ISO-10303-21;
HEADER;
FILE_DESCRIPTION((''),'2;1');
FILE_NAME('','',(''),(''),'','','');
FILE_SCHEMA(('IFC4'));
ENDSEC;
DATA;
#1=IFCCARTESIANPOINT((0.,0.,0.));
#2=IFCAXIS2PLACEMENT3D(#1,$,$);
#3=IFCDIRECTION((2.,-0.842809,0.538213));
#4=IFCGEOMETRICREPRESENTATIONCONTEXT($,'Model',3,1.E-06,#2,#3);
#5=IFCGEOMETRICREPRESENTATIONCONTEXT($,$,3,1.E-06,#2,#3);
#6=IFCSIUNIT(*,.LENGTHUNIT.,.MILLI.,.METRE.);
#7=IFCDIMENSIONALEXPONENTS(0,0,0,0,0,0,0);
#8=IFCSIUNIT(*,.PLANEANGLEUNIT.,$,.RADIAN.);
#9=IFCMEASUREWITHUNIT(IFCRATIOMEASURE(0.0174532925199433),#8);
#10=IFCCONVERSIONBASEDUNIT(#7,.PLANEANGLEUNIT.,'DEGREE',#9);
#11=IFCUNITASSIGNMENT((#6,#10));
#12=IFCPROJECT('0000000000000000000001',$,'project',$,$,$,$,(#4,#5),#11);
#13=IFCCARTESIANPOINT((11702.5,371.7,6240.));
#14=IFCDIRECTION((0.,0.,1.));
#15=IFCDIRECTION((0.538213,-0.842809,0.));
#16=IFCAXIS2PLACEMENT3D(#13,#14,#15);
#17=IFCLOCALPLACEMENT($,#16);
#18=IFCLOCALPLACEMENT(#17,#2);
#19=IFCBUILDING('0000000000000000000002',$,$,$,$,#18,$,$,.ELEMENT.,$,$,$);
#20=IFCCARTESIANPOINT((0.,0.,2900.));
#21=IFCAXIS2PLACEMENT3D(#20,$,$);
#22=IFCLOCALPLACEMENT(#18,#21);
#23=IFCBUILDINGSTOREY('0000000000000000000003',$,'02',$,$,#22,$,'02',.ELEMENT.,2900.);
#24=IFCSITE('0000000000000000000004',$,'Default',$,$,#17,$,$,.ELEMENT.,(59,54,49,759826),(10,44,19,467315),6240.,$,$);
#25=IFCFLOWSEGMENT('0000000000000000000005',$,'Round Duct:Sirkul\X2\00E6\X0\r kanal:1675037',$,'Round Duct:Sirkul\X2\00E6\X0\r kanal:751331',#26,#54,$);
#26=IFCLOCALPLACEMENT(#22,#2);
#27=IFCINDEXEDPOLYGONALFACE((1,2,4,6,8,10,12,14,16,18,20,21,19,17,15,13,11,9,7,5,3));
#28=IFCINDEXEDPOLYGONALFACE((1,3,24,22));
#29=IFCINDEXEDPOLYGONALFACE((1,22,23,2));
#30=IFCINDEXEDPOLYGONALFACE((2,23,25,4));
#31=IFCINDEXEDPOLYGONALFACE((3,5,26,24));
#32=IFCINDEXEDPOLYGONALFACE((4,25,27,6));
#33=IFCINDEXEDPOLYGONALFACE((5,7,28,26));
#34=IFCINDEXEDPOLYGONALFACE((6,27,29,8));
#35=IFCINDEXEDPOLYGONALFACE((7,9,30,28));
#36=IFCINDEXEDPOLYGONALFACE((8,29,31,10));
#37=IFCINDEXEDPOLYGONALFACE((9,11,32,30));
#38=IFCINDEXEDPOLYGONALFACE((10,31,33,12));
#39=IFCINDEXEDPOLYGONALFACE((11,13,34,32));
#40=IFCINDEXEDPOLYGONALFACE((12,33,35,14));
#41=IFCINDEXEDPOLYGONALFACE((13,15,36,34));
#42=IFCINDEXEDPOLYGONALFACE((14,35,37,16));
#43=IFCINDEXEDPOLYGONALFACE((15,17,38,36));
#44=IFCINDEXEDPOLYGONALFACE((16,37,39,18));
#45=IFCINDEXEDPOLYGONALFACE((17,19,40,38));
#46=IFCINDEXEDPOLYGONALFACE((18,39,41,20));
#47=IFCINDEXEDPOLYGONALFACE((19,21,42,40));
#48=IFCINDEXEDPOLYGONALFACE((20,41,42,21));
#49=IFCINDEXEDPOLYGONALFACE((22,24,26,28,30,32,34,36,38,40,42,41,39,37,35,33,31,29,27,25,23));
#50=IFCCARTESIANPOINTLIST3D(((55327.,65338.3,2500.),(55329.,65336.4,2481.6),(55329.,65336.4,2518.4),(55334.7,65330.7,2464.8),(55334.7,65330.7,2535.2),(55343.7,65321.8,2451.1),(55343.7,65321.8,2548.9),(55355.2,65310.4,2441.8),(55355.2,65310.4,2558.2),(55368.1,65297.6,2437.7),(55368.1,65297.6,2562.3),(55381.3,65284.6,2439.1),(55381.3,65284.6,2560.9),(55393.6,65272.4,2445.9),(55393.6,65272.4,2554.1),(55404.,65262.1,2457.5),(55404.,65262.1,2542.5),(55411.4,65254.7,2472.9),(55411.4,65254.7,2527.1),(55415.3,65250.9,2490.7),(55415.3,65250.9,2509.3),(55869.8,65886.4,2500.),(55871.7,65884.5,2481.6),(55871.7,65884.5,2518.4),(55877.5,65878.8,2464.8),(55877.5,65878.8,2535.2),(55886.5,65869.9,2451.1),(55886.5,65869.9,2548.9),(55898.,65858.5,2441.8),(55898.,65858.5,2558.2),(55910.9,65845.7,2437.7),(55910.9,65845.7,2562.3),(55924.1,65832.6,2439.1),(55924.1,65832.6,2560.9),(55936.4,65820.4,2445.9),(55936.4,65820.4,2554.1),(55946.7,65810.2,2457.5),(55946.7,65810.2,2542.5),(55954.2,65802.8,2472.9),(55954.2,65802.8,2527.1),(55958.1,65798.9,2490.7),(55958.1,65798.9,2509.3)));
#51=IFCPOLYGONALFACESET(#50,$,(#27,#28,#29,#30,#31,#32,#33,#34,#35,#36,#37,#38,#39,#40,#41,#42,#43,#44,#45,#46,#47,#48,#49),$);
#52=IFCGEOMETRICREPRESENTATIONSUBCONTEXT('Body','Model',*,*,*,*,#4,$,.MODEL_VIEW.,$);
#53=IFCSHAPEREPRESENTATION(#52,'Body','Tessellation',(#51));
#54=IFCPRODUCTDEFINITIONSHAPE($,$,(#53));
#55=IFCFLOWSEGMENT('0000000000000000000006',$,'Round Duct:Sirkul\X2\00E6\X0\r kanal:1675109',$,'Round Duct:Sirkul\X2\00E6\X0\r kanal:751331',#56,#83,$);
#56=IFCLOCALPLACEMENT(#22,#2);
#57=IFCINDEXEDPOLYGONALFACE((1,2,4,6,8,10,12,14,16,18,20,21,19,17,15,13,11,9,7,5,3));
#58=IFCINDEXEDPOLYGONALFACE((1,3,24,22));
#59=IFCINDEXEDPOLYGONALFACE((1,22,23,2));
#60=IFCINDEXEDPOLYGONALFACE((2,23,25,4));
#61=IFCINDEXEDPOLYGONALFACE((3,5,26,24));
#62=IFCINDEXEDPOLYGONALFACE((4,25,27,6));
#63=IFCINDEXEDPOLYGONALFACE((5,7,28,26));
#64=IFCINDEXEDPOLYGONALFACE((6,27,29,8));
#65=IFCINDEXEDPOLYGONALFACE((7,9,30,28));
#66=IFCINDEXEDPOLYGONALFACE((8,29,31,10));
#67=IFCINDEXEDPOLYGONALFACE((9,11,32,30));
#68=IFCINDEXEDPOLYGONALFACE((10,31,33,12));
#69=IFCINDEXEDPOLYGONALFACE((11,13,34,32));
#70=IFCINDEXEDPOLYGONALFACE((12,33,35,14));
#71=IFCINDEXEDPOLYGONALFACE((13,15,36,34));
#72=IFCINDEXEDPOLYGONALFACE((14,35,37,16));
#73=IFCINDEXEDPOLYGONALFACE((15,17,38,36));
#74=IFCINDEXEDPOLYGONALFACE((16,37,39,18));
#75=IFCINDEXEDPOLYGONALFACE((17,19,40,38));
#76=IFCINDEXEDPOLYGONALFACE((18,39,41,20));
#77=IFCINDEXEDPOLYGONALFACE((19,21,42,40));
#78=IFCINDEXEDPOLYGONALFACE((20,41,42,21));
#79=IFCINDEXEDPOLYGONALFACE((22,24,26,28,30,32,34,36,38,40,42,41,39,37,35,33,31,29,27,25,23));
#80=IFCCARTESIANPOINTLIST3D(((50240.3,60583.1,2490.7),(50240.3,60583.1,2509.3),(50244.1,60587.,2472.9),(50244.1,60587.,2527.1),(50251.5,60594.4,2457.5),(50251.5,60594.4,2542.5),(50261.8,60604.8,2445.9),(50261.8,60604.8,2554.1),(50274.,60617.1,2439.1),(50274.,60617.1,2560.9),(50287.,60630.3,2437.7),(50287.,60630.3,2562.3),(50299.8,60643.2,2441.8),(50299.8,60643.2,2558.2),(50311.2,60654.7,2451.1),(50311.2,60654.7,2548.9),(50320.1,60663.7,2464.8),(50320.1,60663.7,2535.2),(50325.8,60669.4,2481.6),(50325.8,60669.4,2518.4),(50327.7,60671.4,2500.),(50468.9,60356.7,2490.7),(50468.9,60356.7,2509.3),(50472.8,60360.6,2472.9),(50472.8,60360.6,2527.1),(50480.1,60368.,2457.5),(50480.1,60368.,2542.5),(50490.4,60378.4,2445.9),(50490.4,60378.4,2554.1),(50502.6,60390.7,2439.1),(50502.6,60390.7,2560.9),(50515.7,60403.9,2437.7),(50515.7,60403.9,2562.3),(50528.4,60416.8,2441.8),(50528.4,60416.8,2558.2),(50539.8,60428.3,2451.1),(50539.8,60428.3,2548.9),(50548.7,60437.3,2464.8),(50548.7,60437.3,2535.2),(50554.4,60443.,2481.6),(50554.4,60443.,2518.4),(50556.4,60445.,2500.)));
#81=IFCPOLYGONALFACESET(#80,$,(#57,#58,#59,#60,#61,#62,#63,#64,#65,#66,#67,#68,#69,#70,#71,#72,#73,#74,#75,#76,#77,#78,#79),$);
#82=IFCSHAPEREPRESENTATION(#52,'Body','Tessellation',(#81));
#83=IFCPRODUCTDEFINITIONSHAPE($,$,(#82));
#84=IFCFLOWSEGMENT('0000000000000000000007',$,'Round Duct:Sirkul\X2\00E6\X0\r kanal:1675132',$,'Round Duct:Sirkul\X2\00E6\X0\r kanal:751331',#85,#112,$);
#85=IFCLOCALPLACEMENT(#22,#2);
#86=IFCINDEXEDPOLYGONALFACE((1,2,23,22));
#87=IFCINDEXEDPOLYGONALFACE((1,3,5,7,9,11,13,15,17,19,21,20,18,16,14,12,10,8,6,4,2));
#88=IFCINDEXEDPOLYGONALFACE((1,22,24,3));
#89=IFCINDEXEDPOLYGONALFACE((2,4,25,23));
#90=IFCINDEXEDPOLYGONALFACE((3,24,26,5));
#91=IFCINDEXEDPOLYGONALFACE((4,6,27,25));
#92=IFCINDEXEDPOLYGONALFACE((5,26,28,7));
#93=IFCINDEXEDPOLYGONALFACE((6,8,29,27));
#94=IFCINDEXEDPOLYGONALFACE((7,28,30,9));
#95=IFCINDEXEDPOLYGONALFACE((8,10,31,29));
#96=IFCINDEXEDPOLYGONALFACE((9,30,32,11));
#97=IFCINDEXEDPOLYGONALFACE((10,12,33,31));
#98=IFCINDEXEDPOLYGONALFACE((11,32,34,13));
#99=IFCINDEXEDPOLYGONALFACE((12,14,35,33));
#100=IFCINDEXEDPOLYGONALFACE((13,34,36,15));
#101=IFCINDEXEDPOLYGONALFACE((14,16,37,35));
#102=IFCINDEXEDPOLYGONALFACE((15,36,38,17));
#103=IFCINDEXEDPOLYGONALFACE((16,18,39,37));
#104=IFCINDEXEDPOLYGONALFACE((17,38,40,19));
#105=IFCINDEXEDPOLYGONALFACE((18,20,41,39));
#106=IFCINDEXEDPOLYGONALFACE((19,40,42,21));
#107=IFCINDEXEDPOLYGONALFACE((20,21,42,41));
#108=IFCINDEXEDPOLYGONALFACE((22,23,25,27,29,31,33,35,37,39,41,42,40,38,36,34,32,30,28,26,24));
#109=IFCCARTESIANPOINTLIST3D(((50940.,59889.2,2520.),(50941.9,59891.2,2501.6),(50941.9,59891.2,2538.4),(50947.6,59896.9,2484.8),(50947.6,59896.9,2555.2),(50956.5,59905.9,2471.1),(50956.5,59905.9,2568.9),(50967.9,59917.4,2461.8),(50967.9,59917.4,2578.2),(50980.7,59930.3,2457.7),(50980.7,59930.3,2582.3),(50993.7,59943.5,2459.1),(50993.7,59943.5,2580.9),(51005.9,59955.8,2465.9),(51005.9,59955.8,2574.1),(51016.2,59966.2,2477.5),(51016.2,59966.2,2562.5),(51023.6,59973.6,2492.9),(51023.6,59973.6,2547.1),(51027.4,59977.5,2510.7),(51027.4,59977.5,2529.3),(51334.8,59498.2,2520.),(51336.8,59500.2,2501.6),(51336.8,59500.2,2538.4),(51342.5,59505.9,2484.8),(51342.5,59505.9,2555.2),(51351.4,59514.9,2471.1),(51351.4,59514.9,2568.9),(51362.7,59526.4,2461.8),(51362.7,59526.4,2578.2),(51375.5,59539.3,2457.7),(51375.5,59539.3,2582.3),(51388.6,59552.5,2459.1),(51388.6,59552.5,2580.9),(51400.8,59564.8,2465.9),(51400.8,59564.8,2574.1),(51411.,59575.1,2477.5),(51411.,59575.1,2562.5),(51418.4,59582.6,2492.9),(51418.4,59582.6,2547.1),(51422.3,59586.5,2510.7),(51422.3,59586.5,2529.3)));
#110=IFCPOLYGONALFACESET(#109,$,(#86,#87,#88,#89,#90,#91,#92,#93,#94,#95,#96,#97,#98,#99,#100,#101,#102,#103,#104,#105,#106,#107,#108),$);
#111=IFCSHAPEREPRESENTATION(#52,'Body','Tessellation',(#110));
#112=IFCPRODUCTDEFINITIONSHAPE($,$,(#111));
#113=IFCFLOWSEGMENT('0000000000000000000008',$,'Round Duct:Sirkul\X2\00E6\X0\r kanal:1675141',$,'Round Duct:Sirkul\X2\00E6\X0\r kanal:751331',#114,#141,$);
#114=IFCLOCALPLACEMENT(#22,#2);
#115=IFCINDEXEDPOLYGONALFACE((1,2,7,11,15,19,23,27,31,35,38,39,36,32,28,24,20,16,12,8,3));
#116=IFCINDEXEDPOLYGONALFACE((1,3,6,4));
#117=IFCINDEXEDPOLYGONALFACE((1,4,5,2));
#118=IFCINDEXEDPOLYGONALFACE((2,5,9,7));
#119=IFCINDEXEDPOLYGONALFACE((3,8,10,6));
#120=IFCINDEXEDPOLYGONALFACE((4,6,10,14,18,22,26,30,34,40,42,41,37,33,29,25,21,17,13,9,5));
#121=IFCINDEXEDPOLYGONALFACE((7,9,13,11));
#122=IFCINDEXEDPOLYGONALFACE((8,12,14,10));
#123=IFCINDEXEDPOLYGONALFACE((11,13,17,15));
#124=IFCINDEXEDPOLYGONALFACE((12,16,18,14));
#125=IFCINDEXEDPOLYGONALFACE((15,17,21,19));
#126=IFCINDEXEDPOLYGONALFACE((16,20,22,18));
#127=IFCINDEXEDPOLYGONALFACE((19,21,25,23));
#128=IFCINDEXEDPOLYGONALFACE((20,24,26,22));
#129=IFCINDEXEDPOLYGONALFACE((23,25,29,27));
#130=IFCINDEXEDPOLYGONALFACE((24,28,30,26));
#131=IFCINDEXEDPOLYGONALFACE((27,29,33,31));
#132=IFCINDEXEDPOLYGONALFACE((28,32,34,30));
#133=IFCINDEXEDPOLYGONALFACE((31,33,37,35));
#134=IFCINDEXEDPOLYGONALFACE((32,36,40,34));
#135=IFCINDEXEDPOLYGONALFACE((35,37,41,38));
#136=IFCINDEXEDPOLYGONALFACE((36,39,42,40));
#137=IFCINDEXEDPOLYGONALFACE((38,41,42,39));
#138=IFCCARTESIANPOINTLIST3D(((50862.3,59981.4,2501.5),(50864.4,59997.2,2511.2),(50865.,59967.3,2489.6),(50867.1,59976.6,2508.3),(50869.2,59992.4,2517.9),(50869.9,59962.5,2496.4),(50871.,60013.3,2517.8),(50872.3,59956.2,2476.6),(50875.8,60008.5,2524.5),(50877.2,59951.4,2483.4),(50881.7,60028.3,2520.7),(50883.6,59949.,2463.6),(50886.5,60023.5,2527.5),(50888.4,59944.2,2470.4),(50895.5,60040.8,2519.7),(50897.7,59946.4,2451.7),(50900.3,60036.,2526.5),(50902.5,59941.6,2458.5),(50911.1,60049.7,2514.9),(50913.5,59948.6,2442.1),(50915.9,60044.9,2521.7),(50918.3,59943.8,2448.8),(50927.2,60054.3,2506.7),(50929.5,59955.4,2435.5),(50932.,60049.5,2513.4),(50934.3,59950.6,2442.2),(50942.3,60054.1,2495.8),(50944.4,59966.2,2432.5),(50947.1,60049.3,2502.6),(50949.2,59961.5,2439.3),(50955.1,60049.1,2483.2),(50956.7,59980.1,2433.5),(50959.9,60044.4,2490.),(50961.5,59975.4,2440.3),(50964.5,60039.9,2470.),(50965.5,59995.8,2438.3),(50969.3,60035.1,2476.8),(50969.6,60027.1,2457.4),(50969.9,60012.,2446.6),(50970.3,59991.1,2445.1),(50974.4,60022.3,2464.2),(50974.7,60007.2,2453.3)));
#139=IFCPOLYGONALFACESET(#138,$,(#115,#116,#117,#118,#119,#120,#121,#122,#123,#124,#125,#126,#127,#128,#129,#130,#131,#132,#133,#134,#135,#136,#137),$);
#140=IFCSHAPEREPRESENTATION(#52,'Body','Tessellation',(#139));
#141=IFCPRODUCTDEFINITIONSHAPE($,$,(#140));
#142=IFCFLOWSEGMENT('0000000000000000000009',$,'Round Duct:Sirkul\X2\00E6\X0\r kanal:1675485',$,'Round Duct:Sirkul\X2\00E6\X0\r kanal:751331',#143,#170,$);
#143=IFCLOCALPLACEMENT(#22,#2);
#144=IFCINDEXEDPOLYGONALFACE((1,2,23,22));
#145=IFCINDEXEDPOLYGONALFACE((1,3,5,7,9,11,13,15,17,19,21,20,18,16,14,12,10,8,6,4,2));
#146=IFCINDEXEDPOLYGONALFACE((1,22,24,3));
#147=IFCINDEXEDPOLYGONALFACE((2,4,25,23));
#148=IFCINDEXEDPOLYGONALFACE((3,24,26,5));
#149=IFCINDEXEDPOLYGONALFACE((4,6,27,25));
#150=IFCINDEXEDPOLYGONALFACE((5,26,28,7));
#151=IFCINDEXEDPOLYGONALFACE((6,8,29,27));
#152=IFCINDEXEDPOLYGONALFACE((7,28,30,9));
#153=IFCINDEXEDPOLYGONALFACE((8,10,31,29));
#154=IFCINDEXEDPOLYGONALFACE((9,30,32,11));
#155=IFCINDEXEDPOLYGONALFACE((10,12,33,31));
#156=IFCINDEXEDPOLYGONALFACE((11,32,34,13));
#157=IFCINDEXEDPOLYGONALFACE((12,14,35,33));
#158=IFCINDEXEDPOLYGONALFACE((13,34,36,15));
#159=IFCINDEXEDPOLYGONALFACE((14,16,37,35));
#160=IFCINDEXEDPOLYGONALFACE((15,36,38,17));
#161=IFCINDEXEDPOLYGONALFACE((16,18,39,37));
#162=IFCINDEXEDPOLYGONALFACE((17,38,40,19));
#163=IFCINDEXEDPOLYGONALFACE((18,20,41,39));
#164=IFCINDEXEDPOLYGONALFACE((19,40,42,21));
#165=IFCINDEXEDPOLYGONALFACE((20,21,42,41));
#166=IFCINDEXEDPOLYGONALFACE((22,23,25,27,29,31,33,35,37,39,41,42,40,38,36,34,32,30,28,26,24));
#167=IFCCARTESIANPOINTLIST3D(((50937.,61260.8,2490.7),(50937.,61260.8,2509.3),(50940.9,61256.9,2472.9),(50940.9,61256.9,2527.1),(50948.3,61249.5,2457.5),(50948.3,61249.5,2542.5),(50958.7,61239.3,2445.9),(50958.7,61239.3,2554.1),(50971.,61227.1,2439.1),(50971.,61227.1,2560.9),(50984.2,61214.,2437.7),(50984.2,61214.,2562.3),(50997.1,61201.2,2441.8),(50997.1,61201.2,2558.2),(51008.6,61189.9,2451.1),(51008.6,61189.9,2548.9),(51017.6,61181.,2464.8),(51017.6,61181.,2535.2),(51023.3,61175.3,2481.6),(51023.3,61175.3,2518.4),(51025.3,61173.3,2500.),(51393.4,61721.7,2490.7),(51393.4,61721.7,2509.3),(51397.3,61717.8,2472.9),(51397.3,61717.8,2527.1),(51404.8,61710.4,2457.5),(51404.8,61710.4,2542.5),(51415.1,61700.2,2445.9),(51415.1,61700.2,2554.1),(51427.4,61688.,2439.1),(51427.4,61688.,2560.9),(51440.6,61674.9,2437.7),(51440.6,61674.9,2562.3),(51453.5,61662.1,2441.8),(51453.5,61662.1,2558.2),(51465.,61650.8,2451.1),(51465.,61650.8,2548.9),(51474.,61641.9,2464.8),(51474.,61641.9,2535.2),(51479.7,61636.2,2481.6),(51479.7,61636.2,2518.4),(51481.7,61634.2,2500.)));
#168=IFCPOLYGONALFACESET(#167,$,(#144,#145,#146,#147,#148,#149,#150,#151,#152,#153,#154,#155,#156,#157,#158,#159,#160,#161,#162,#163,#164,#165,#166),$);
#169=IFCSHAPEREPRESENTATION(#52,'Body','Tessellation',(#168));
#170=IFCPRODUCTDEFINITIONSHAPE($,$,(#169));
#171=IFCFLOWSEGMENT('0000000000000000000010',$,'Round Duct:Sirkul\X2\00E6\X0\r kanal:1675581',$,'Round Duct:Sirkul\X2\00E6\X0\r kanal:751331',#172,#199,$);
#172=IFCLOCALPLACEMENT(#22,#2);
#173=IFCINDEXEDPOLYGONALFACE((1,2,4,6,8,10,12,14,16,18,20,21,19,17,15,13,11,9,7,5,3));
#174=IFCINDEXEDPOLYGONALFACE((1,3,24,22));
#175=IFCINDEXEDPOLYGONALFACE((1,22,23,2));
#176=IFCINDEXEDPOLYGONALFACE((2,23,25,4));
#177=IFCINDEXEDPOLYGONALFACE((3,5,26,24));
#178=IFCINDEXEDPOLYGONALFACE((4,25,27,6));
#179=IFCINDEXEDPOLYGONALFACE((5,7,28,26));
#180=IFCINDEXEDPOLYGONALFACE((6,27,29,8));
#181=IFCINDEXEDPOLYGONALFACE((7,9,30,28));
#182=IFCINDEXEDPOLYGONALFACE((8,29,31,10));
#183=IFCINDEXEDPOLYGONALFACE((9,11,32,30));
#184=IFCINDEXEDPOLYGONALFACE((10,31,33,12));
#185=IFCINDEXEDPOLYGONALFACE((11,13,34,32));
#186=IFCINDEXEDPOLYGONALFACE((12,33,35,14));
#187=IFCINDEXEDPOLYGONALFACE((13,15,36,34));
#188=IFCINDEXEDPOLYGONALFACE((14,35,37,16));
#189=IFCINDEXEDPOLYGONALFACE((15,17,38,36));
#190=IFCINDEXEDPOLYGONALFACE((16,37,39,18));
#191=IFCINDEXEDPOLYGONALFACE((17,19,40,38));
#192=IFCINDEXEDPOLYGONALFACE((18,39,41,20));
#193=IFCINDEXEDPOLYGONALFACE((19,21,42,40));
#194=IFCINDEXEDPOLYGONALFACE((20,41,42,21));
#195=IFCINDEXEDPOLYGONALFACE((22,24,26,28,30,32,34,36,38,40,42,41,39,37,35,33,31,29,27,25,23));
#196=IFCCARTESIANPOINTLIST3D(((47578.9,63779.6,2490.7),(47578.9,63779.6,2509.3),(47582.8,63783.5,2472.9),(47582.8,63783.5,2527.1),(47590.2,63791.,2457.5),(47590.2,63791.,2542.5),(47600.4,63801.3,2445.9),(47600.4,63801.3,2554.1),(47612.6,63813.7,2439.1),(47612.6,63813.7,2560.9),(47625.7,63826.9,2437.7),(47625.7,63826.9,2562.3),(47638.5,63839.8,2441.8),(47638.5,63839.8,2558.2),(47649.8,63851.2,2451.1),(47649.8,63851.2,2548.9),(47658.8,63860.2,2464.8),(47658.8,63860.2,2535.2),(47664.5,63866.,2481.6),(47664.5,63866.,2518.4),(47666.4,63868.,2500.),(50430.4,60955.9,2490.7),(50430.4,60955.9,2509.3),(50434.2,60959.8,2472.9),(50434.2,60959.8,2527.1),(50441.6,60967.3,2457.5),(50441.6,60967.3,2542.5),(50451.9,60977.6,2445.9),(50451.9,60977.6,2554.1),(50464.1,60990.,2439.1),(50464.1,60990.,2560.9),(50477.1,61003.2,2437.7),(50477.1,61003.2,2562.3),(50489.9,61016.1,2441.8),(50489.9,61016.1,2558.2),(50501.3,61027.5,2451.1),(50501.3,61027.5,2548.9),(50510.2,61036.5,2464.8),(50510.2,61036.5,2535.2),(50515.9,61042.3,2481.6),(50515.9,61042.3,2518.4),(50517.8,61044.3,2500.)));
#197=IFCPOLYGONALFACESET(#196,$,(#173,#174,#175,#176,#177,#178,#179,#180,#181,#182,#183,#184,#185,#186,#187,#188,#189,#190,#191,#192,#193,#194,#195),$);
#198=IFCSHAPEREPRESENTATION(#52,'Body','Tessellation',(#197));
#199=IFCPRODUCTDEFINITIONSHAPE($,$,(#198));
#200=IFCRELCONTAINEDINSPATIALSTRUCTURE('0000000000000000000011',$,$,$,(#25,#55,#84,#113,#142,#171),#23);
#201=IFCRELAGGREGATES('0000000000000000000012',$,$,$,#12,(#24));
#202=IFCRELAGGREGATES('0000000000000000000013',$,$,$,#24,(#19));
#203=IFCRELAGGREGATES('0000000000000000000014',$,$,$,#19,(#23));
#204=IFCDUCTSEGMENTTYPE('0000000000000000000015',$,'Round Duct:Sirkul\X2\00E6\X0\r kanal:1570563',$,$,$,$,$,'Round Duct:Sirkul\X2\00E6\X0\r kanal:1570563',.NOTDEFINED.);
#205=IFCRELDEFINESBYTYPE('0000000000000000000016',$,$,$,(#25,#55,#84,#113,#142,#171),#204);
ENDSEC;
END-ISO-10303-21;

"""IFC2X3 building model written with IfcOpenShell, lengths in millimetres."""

from ifc_helpers import new_model, entity, si_unit, converted_unit, direction, frame, frame_2d, origin, origin_2d_with_axis, place, context, subcontext, project, spatial, circle, extrude, type_object, element, save


model = new_model("IFC2X3")

# Units and contexts
model_context = context("Model", 3, precision=1e-06, world=origin(), true_north=direction((2.0, -0.842809, 0.538213)))
context_of_model = context(None, 3, precision=1e-06, world=origin(), true_north=direction((2.0, -0.842809, 0.538213)))
body_context = subcontext(model_context, "Body", "Model", "MODEL_VIEW")
ifc_project = project(units=[si_unit("LENGTHUNIT", "METRE", prefix="MILLI"), converted_unit("PLANEANGLEUNIT", "DEGREE", entity("IfcRatioMeasure", 0.0174532925199433), si_unit("PLANEANGLEUNIT", "RADIAN"), dimensions=[0, 0, 0, 0, 0, 0, 0])], contexts=[model_context, context_of_model])

# Site, building, storey
site_placement = place(None, frame((11702.5, 371.7, 6240.0), z_axis=(0.0, 0.0, 1.0), x_axis=(0.538213, -0.842809, 0.0)))
site = spatial("IfcSite", under=ifc_project, at=site_placement, Name="Default", CompositionType="ELEMENT", RefLatitude=(59, 54, 49, 759826), RefLongitude=(10, 44, 19, 467315), RefElevation=6240.0)
building_placement = place(site_placement, origin())
building = spatial("IfcBuilding", under=site, at=building_placement, CompositionType="ELEMENT")
storey_placement = place(building_placement, frame((0.0, 0.0, 2900.0)))
storey = spatial("IfcBuildingStorey", under=building, at=storey_placement, Name="02", LongName="02", CompositionType="ELEMENT", Elevation=2900.0)

# Flow segments
duct_segment_type_1 = type_object("IfcDuctSegmentType", Name="Round Duct:Sirkulær kanal:1570563", ElementType="Round Duct:Sirkulær kanal:1570563", PredefinedType="NOTDEFINED")
flow_segment_1_placement = place(storey_placement, origin())
element("IfcFlowSegment", 1, at=flow_segment_1_placement, inside=storey, type_object=duct_segment_type_1, Name="Round Duct:Sirkulær kanal:1675037", ObjectType="Round Duct:Sirkulær kanal:751331", context=body_context, shape_type="SweptSolid", body=[
    extrude(circle(Radius=62.5, at=frame_2d((0.0, 0.0), x_axis=(1.0, 0.0))), frame((55371.4, 65294.4, 2500.0), z_axis=(0.703643, 0.710554, 0.0), x_axis=(-0.710554, 0.703643, 0.0)), (0.0, 0.0, 1.0), 771.3),
])
flow_segment_2_placement = place(storey_placement, origin())
element("IfcFlowSegment", 2, at=flow_segment_2_placement, inside=storey, type_object=duct_segment_type_1, Name="Round Duct:Sirkulær kanal:1675109", ObjectType="Round Duct:Sirkulær kanal:751331", context=body_context, shape_type="SweptSolid", body=[
    extrude(circle(Radius=62.5, at=frame_2d((0.0, 0.0), x_axis=(1.0, 0.0))), frame((50283.7, 60627.0, 2500.0), z_axis=(0.710554, -0.703643, 0.0), x_axis=(0.703643, 0.710554, 0.0)), (0.0, 0.0, 1.0), 321.8),
])
flow_segment_3_placement = place(storey_placement, origin())
element("IfcFlowSegment", 3, at=flow_segment_3_placement, inside=storey, type_object=duct_segment_type_1, Name="Round Duct:Sirkulær kanal:1675132", ObjectType="Round Duct:Sirkulær kanal:751331", context=body_context, shape_type="SweptSolid", body=[
    extrude(circle(Radius=62.5, at=origin_2d_with_axis()), frame((51378.8, 59542.6, 2520.0), z_axis=(-0.710554, 0.703643, 0.0), x_axis=(-0.703643, -0.710554, 0.0)), (0.0, 0.0, 1.0), 555.7),
])
flow_segment_4_placement = place(storey_placement, origin())
element("IfcFlowSegment", 4, at=flow_segment_4_placement, inside=storey, type_object=duct_segment_type_1, Name="Round Duct:Sirkulær kanal:1675141", ObjectType="Round Duct:Sirkulær kanal:751331", context=body_context, shape_type="SweptSolid", body=[
    extrude(circle(Radius=62.5, at=origin_2d_with_axis()), frame((50916.3, 60000.6, 2476.6), z_axis=(0.502437, -0.49755, 0.707107), x_axis=(-0.703643, -0.710554, 0.0)), (0.0, 0.0, 1.0), 9.6),
])
flow_segment_5_placement = place(storey_placement, origin())
element("IfcFlowSegment", 5, at=flow_segment_5_placement, inside=storey, type_object=duct_segment_type_1, Name="Round Duct:Sirkulær kanal:1675485", ObjectType="Round Duct:Sirkulær kanal:751331", context=body_context, shape_type="SweptSolid", body=[
    extrude(circle(Radius=62.5, at=origin_2d_with_axis()), frame((50980.9, 61217.3, 2500.0), z_axis=(0.703643, 0.710554, 0.0), x_axis=(0.710554, -0.703643, 0.0)), (0.0, 0.0, 1.0), 648.7),
])
flow_segment_6_placement = place(storey_placement, origin())
element("IfcFlowSegment", 6, at=flow_segment_6_placement, inside=storey, type_object=duct_segment_type_1, Name="Round Duct:Sirkulær kanal:1675581", ObjectType="Round Duct:Sirkulær kanal:751331", context=body_context, shape_type="SweptSolid", body=[
    extrude(circle(Radius=62.5, at=origin_2d_with_axis()), frame((50473.9, 60999.9, 2500.0), z_axis=(-0.710554, 0.703643, 0.0), x_axis=(0.703643, 0.710554, 0.0)), (0.0, 0.0, 1.0), 4013.0),
])

save(model, "model.ifc")
